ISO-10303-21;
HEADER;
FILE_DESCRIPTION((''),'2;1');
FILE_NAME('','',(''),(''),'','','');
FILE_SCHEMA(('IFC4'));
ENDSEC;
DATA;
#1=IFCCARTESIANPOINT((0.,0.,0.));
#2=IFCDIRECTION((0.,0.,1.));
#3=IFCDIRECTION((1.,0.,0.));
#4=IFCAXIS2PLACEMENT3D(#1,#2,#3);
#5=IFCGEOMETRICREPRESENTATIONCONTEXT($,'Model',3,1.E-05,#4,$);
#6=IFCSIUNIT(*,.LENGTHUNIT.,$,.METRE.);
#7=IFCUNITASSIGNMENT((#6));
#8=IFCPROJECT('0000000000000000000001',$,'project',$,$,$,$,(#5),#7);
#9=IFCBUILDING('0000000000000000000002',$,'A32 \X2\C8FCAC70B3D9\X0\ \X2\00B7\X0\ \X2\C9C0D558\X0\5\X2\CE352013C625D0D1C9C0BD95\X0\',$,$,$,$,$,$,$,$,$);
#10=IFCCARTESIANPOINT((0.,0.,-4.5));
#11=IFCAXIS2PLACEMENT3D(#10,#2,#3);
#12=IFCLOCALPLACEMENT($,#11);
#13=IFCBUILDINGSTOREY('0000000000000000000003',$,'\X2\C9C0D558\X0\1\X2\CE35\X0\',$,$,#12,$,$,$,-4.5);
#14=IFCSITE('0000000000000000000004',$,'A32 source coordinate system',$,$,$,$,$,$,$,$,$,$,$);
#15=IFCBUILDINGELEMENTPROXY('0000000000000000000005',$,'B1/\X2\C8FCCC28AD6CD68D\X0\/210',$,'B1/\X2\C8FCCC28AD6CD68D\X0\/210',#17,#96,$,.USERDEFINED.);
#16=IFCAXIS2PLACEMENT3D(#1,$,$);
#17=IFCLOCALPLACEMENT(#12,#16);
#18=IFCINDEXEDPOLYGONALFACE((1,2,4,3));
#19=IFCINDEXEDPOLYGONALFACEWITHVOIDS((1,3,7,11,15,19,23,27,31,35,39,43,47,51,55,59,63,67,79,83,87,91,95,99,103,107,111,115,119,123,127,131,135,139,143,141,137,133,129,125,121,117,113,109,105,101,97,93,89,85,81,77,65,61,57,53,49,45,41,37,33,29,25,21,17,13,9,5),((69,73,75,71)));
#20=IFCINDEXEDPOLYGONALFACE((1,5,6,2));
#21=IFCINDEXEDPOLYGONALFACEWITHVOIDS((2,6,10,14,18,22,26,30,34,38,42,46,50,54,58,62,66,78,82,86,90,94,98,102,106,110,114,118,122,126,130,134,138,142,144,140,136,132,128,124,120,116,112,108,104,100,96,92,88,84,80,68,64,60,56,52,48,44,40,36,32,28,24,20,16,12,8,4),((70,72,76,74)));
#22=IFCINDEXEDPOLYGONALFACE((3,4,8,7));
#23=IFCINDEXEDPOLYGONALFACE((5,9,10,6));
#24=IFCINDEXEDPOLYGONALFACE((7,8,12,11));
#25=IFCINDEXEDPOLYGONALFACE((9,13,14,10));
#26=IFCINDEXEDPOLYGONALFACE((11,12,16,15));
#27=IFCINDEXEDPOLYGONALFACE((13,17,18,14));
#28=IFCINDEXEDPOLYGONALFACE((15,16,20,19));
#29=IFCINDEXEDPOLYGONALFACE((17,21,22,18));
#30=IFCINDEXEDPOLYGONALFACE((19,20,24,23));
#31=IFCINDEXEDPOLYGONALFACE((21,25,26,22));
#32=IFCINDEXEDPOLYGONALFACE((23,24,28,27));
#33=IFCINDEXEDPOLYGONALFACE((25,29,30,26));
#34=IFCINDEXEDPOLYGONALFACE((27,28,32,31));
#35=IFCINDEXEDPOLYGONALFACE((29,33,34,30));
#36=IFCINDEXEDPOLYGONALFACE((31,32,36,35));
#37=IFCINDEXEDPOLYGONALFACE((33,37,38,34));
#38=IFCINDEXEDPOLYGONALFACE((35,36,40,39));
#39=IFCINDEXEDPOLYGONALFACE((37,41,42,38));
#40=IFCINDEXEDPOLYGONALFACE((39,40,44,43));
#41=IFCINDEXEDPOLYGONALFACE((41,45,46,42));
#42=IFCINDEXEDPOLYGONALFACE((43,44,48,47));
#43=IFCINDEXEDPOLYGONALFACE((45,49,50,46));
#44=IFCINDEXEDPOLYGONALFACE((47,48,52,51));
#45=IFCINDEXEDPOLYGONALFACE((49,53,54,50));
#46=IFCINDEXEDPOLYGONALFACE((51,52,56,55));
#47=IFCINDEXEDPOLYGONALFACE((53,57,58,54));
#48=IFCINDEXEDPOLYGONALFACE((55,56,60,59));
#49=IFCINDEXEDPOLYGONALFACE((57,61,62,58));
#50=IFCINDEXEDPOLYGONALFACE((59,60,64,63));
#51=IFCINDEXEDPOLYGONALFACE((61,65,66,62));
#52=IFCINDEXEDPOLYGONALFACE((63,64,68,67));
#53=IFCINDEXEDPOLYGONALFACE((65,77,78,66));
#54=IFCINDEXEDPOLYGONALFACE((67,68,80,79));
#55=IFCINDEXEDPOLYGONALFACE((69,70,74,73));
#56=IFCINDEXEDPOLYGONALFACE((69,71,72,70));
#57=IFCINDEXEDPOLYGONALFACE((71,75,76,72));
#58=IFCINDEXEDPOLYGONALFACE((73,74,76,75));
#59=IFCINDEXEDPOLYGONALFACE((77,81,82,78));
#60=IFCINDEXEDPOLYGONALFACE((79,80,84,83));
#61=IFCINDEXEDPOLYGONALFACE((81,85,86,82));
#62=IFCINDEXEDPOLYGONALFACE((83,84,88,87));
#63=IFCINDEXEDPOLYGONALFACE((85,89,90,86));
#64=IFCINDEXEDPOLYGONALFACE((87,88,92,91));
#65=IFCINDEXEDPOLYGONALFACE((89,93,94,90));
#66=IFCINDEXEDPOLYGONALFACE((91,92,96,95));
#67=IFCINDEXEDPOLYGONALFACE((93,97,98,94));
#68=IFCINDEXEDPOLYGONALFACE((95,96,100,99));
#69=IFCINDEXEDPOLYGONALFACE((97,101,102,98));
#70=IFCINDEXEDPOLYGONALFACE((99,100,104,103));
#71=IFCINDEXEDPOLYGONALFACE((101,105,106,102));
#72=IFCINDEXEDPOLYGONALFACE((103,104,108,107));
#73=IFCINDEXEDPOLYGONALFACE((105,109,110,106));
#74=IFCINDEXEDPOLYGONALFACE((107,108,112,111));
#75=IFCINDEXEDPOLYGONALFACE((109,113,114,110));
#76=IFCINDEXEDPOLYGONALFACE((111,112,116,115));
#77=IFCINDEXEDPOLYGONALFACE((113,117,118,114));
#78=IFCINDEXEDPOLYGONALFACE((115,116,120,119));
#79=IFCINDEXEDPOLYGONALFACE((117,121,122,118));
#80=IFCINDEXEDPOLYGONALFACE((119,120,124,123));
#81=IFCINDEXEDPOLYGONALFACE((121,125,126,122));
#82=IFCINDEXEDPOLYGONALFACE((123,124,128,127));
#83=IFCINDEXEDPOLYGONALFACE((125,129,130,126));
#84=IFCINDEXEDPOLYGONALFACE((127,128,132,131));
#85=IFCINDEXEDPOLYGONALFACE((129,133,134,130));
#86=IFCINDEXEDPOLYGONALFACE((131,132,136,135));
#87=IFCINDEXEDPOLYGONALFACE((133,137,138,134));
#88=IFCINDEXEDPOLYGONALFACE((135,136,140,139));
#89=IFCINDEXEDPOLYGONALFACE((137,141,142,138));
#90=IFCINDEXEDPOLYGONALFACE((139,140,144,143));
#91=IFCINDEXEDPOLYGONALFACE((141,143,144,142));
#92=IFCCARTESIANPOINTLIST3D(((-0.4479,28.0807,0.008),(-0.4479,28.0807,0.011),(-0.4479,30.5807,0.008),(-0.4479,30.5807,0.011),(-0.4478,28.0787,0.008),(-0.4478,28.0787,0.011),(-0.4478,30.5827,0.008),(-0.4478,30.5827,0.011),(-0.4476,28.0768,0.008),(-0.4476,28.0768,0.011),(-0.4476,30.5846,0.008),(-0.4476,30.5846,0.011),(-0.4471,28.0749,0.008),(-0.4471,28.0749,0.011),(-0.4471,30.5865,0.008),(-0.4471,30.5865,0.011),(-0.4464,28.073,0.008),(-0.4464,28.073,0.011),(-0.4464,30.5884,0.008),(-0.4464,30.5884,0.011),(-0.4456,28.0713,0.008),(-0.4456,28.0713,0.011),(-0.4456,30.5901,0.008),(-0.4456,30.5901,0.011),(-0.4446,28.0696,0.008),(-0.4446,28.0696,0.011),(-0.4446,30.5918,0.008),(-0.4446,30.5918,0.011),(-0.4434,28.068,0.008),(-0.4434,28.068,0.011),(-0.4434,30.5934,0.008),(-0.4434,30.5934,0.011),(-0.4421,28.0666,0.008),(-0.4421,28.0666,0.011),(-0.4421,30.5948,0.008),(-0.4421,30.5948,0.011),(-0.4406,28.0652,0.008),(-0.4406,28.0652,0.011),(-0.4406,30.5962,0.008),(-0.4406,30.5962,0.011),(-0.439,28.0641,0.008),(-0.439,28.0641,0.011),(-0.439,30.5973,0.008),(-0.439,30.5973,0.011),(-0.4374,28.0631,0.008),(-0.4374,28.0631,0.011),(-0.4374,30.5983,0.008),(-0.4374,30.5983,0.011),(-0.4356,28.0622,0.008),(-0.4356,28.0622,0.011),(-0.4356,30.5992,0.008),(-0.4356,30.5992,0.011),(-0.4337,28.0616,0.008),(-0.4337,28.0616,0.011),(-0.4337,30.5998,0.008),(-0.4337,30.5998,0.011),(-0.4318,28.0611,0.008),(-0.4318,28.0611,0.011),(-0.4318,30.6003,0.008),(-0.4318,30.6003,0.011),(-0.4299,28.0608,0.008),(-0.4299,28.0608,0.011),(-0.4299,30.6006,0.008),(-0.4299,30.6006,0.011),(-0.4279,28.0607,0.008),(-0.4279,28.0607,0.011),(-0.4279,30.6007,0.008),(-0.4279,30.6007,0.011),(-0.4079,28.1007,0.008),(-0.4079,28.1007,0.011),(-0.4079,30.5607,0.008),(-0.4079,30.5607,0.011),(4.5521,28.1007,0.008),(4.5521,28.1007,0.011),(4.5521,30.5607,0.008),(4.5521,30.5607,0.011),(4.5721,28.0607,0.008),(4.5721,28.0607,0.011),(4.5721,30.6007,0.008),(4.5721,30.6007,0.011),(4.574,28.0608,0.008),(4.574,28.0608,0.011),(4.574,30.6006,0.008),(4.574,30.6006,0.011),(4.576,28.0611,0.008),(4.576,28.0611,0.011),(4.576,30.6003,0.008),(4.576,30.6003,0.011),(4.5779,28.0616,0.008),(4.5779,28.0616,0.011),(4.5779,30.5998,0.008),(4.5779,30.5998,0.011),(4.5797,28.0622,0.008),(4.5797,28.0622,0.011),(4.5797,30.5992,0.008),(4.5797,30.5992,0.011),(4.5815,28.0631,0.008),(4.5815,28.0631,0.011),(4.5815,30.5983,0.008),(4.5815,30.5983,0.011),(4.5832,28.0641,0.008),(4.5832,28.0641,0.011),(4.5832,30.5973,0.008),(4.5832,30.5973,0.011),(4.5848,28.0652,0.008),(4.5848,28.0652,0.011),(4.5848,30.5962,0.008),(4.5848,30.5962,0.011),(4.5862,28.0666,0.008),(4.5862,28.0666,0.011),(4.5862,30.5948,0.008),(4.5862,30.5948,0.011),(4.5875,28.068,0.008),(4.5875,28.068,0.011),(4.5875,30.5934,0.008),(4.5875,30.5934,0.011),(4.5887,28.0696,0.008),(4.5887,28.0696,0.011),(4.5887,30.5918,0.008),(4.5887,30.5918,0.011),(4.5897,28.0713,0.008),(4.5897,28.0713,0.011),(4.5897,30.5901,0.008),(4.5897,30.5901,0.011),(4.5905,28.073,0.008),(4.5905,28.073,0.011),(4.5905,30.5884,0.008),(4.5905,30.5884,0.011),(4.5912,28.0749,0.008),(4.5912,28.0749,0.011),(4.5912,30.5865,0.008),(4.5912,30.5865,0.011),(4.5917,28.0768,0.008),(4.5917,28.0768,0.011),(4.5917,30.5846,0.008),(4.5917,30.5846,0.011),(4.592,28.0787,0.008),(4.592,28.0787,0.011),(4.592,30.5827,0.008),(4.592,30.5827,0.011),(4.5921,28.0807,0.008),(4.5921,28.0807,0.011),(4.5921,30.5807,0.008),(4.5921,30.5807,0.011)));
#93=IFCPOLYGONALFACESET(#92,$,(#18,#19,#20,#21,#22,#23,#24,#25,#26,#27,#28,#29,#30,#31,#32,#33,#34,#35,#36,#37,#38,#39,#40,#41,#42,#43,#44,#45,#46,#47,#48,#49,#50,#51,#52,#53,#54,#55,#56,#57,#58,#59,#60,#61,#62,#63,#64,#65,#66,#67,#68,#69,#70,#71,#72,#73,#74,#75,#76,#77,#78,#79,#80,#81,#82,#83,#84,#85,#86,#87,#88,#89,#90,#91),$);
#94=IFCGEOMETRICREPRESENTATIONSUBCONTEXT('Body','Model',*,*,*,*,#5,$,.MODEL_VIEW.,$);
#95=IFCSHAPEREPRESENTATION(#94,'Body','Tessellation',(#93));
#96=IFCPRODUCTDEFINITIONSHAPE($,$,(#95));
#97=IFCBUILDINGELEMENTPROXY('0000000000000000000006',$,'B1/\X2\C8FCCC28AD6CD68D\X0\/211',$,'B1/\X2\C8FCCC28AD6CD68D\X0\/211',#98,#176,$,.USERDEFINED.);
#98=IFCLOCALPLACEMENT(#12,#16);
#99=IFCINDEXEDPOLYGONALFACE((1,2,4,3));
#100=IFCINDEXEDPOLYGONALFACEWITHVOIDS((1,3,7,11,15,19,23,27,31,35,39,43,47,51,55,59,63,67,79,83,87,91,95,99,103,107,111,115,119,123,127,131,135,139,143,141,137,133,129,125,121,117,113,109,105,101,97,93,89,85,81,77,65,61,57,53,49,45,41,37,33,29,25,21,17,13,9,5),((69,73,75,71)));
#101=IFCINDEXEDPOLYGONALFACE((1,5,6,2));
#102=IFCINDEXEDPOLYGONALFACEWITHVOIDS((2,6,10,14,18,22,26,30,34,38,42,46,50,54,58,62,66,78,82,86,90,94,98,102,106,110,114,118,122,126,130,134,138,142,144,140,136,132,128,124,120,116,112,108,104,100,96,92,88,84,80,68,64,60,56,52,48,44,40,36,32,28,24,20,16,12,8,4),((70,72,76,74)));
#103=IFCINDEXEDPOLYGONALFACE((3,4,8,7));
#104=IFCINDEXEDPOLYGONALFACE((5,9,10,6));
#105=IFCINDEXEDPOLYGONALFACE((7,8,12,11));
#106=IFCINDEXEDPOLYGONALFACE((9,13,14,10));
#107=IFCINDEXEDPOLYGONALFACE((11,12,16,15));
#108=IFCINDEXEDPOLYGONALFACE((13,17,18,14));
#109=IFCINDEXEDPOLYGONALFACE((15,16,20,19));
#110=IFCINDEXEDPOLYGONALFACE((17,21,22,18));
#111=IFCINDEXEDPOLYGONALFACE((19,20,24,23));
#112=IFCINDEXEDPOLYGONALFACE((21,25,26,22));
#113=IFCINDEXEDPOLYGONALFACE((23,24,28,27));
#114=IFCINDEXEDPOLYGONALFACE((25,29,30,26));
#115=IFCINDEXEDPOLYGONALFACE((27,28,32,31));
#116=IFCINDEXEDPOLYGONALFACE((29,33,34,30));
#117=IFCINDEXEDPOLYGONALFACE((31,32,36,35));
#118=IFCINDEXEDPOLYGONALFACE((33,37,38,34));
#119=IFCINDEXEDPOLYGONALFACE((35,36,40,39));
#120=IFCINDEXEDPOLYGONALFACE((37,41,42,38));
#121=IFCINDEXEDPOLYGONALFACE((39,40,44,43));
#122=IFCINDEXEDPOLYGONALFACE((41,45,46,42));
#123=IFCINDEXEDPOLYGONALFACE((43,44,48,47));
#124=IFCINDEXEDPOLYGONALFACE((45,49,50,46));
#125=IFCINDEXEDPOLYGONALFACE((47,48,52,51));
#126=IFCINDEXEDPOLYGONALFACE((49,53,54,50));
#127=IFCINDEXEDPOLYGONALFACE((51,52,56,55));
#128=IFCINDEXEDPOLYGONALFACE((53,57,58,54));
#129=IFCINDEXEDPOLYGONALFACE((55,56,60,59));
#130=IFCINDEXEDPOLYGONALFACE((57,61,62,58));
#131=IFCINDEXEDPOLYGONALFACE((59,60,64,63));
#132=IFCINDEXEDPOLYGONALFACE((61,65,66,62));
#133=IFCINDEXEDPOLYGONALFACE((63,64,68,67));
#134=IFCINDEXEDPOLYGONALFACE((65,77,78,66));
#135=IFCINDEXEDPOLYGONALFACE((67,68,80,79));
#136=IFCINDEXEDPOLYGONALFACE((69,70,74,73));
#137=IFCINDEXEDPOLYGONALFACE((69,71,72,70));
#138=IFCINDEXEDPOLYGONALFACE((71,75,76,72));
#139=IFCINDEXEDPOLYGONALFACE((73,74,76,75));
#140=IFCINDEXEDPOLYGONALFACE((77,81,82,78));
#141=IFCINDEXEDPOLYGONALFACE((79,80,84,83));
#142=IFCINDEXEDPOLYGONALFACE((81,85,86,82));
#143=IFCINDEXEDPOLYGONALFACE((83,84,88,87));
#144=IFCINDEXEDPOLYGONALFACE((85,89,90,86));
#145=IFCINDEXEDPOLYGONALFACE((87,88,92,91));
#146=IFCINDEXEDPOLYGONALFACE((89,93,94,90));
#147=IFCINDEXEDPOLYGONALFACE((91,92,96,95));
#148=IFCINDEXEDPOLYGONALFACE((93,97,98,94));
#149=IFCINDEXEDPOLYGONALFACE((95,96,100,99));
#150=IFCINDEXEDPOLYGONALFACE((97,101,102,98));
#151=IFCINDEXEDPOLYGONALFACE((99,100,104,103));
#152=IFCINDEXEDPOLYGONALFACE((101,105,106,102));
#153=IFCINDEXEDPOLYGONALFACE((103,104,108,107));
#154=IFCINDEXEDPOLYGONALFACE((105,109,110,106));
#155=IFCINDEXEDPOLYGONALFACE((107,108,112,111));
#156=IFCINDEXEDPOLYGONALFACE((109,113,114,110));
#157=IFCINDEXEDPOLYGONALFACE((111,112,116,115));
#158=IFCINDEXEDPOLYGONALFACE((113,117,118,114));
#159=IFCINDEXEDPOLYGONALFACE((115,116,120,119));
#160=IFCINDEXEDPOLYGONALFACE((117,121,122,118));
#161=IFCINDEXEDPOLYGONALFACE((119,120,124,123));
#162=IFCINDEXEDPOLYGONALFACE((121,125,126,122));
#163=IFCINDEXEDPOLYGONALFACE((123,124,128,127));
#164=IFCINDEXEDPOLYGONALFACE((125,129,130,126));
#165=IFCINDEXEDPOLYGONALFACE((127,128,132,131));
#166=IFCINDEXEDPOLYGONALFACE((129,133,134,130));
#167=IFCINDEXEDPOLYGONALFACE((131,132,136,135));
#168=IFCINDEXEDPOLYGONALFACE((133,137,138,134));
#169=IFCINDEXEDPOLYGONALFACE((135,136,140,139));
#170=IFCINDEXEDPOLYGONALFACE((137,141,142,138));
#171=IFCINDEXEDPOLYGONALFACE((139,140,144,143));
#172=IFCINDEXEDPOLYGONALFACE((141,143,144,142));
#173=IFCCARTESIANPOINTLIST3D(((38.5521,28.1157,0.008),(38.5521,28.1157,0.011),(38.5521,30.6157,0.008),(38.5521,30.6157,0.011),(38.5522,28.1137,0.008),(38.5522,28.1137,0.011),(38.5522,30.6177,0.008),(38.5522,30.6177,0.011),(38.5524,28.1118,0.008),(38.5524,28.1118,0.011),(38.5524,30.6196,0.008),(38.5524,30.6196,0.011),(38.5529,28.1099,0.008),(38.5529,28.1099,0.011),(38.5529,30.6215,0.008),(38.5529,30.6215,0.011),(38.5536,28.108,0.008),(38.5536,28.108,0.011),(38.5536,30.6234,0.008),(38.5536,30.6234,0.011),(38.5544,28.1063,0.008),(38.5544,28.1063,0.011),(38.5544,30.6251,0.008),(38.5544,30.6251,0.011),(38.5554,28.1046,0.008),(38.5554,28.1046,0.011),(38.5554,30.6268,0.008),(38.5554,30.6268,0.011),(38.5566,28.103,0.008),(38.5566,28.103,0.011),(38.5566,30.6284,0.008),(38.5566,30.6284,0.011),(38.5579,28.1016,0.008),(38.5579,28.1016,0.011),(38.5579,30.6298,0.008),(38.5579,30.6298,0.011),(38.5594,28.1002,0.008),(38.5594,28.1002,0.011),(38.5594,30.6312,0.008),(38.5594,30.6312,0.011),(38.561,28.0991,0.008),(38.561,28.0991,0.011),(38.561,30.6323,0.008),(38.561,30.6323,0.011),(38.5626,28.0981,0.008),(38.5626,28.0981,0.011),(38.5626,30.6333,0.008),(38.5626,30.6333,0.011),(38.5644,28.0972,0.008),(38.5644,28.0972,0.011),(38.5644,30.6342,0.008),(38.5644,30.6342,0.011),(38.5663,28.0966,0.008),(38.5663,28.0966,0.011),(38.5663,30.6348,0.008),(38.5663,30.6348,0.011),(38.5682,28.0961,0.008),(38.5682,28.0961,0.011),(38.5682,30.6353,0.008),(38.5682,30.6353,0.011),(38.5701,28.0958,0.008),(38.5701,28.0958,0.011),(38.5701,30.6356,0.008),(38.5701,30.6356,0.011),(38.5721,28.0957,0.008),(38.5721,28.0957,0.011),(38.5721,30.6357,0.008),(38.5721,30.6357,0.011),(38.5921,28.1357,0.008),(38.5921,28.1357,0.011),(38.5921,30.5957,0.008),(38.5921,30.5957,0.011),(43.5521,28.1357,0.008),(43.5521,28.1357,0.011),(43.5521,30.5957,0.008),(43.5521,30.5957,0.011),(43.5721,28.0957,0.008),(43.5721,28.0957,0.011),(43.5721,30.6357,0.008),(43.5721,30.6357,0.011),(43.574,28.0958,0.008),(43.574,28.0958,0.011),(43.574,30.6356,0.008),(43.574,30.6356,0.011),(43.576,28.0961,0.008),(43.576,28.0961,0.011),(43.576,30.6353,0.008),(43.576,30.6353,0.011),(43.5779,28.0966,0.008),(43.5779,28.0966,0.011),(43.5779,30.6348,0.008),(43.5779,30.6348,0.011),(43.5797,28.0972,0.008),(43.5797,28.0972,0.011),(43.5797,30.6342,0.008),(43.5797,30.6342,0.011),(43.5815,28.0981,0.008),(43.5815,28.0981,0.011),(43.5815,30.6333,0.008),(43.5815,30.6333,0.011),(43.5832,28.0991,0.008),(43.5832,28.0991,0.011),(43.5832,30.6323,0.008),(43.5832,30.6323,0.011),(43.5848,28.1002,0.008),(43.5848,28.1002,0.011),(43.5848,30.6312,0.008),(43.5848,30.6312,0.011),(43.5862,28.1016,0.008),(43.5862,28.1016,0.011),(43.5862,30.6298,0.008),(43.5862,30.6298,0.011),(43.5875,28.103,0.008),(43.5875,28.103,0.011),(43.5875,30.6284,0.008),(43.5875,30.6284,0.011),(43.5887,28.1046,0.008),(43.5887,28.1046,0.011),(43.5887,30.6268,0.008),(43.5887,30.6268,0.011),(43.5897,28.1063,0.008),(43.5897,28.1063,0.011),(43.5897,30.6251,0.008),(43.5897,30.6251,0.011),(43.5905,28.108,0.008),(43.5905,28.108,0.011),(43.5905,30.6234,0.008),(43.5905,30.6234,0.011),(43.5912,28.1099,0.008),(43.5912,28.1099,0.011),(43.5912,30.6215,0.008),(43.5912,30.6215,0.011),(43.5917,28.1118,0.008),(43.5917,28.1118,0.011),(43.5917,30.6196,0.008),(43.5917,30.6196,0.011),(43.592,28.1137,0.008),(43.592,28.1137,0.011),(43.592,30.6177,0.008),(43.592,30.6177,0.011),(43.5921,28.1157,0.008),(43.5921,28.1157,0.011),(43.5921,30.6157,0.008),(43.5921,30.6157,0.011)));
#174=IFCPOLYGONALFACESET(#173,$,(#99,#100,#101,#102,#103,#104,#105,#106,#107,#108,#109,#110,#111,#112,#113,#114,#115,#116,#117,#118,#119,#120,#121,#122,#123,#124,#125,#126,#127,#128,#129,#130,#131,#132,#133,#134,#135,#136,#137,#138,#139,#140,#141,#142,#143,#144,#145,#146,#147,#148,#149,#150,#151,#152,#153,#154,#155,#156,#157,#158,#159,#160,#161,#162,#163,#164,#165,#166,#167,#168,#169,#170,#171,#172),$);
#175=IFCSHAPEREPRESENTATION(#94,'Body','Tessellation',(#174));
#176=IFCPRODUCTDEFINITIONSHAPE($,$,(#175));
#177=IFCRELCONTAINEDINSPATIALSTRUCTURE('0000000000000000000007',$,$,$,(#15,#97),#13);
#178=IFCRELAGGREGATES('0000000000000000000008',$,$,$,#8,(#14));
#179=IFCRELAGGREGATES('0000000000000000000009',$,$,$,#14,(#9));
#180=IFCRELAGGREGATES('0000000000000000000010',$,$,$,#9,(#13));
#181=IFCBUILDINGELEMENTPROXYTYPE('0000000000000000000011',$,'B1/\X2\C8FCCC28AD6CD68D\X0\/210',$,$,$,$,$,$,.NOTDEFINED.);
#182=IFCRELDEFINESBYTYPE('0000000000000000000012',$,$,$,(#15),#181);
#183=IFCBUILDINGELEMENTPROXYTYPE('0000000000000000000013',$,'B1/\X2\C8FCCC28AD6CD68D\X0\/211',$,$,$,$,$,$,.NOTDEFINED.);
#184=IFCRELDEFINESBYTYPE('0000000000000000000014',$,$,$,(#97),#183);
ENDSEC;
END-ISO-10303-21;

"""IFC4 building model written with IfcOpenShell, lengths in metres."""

from ifc_helpers import new_model, si_unit, frame, origin, origin_with_axes, place, context, subcontext, project, spatial, polyline, outline, extrude, source, transform, mapped, type_object, type_shapes, element, save


model = new_model("IFC4")

# Units and contexts
model_context = context("Model", 3, precision=1e-05, world=origin_with_axes())
body_context = subcontext(model_context, "Body", "Model", "MODEL_VIEW")
ifc_project = project(units=[si_unit("LENGTHUNIT", "METRE")], contexts=[model_context])

# Site, building, storey
site = spatial("IfcSite", under=ifc_project, Name="A32 source coordinate system")
building = spatial("IfcBuilding", under=site, Name="A32 주거동 · 지하5층–옥탑지붕")
storey_placement = place(None, frame((0.0, 0.0, -4.5), z_axis=(0.0, 0.0, 1.0), x_axis=(1.0, 0.0, 0.0)))
storey = spatial("IfcBuildingStorey", under=building, at=storey_placement, Name="지하1층", Elevation=-4.5)

# Building element proxies
building_element_proxy_type_1 = type_object("IfcBuildingElementProxyType", Name="B1/주차구획/210", PredefinedType="NOTDEFINED")
shared_shape_1 = source(origin(), body_context, "Body", "SweptSolid", [
    extrude(outline(polyline([(-0.4279, 28.0607), (-0.4299, 28.0608), (-0.4318, 28.0611), (-0.4337, 28.0616), (-0.4356, 28.0622), (-0.4374, 28.0631), (-0.439, 28.0641), (-0.4406, 28.0652), (-0.4421, 28.0666), (-0.4434, 28.068), (-0.4446, 28.0696), (-0.4456, 28.0713), (-0.4464, 28.073), (-0.4471, 28.0749), (-0.4476, 28.0768), (-0.4478, 28.0787), (-0.4479, 28.0807), (-0.4479, 30.5807), (-0.4478, 30.5827), (-0.4476, 30.5846), (-0.4471, 30.5865), (-0.4464, 30.5884), (-0.4456, 30.5901), (-0.4446, 30.5918), (-0.4434, 30.5934), (-0.4421, 30.5948), (-0.4406, 30.5962), (-0.439, 30.5973), (-0.4374, 30.5983), (-0.4356, 30.5992), (-0.4337, 30.5998), (-0.4318, 30.6003), (-0.4299, 30.6006), (-0.4279, 30.6007), (4.5721, 30.6007), (4.574, 30.6006), (4.576, 30.6003), (4.5779, 30.5998), (4.5797, 30.5992), (4.5815, 30.5983), (4.5832, 30.5973), (4.5848, 30.5962), (4.5862, 30.5948), (4.5875, 30.5934), (4.5887, 30.5918), (4.5897, 30.5901), (4.5905, 30.5884), (4.5912, 30.5865), (4.5917, 30.5846), (4.592, 30.5827), (4.5921, 30.5807), (4.5921, 28.0807), (4.592, 28.0787), (4.5917, 28.0768), (4.5912, 28.0749), (4.5905, 28.073), (4.5897, 28.0713), (4.5887, 28.0696), (4.5875, 28.068), (4.5862, 28.0666), (4.5848, 28.0652), (4.5832, 28.0641), (4.5815, 28.0631), (4.5797, 28.0622), (4.5779, 28.0616), (4.576, 28.0611), (4.574, 28.0608), (4.5721, 28.0607), (-0.4279, 28.0607)]), holes=[polyline([(-0.4079, 28.1007), (4.5521, 28.1007), (4.5521, 30.5607), (-0.4079, 30.5607), (-0.4079, 28.1007)])]), frame((0.0, 0.0, 0.008)), (0.0, 0.0, 1.0), 0.003),
])
type_shapes(building_element_proxy_type_1, [shared_shape_1])
proxy_1_placement = place(storey_placement, origin_with_axes())
element("IfcBuildingElementProxy", 1, at=proxy_1_placement, inside=storey, type_object=building_element_proxy_type_1, Name="B1/주차구획/210", ObjectType="B1/주차구획/210", PredefinedType="USERDEFINED", context=body_context, shape_type="MappedRepresentation", body=[
    mapped(shared_shape_1, transform((0.0, 0.0, 0.0), scale=1.0)),
])
building_element_proxy_type_2 = type_object("IfcBuildingElementProxyType", Name="B1/주차구획/211", PredefinedType="NOTDEFINED")
shared_shape_2 = source(origin(), body_context, "Body", "SweptSolid", [
    extrude(outline(polyline([(43.5721, 30.6357), (43.574, 30.6356), (43.576, 30.6353), (43.5779, 30.6348), (43.5797, 30.6342), (43.5815, 30.6333), (43.5832, 30.6323), (43.5848, 30.6312), (43.5862, 30.6298), (43.5875, 30.6284), (43.5887, 30.6268), (43.5897, 30.6251), (43.5905, 30.6234), (43.5912, 30.6215), (43.5917, 30.6196), (43.592, 30.6177), (43.5921, 30.6157), (43.5921, 28.1157), (43.592, 28.1137), (43.5917, 28.1118), (43.5912, 28.1099), (43.5905, 28.108), (43.5897, 28.1063), (43.5887, 28.1046), (43.5875, 28.103), (43.5862, 28.1016), (43.5848, 28.1002), (43.5832, 28.0991), (43.5815, 28.0981), (43.5797, 28.0972), (43.5779, 28.0966), (43.576, 28.0961), (43.574, 28.0958), (43.5721, 28.0957), (38.5721, 28.0957), (38.5701, 28.0958), (38.5682, 28.0961), (38.5663, 28.0966), (38.5644, 28.0972), (38.5626, 28.0981), (38.561, 28.0991), (38.5594, 28.1002), (38.5579, 28.1016), (38.5566, 28.103), (38.5554, 28.1046), (38.5544, 28.1063), (38.5536, 28.108), (38.5529, 28.1099), (38.5524, 28.1118), (38.5522, 28.1137), (38.5521, 28.1157), (38.5521, 30.6157), (38.5522, 30.6177), (38.5524, 30.6196), (38.5529, 30.6215), (38.5536, 30.6234), (38.5544, 30.6251), (38.5554, 30.6268), (38.5566, 30.6284), (38.5579, 30.6298), (38.5594, 30.6312), (38.561, 30.6323), (38.5626, 30.6333), (38.5644, 30.6342), (38.5663, 30.6348), (38.5682, 30.6353), (38.5701, 30.6356), (38.5721, 30.6357), (43.5721, 30.6357)]), holes=[polyline([(43.5521, 30.5957), (38.5921, 30.5957), (38.5921, 28.1357), (43.5521, 28.1357), (43.5521, 30.5957)])]), frame((0.0, 0.0, 0.008)), (0.0, 0.0, 1.0), 0.003),
])
type_shapes(building_element_proxy_type_2, [shared_shape_2])
proxy_2_placement = place(storey_placement, origin_with_axes())
element("IfcBuildingElementProxy", 2, at=proxy_2_placement, inside=storey, type_object=building_element_proxy_type_2, Name="B1/주차구획/211", ObjectType="B1/주차구획/211", PredefinedType="USERDEFINED", context=body_context, shape_type="MappedRepresentation", body=[
    mapped(shared_shape_2, transform((0.0, 0.0, 0.0), scale=1.0)),
])

save(model, "model.ifc")
